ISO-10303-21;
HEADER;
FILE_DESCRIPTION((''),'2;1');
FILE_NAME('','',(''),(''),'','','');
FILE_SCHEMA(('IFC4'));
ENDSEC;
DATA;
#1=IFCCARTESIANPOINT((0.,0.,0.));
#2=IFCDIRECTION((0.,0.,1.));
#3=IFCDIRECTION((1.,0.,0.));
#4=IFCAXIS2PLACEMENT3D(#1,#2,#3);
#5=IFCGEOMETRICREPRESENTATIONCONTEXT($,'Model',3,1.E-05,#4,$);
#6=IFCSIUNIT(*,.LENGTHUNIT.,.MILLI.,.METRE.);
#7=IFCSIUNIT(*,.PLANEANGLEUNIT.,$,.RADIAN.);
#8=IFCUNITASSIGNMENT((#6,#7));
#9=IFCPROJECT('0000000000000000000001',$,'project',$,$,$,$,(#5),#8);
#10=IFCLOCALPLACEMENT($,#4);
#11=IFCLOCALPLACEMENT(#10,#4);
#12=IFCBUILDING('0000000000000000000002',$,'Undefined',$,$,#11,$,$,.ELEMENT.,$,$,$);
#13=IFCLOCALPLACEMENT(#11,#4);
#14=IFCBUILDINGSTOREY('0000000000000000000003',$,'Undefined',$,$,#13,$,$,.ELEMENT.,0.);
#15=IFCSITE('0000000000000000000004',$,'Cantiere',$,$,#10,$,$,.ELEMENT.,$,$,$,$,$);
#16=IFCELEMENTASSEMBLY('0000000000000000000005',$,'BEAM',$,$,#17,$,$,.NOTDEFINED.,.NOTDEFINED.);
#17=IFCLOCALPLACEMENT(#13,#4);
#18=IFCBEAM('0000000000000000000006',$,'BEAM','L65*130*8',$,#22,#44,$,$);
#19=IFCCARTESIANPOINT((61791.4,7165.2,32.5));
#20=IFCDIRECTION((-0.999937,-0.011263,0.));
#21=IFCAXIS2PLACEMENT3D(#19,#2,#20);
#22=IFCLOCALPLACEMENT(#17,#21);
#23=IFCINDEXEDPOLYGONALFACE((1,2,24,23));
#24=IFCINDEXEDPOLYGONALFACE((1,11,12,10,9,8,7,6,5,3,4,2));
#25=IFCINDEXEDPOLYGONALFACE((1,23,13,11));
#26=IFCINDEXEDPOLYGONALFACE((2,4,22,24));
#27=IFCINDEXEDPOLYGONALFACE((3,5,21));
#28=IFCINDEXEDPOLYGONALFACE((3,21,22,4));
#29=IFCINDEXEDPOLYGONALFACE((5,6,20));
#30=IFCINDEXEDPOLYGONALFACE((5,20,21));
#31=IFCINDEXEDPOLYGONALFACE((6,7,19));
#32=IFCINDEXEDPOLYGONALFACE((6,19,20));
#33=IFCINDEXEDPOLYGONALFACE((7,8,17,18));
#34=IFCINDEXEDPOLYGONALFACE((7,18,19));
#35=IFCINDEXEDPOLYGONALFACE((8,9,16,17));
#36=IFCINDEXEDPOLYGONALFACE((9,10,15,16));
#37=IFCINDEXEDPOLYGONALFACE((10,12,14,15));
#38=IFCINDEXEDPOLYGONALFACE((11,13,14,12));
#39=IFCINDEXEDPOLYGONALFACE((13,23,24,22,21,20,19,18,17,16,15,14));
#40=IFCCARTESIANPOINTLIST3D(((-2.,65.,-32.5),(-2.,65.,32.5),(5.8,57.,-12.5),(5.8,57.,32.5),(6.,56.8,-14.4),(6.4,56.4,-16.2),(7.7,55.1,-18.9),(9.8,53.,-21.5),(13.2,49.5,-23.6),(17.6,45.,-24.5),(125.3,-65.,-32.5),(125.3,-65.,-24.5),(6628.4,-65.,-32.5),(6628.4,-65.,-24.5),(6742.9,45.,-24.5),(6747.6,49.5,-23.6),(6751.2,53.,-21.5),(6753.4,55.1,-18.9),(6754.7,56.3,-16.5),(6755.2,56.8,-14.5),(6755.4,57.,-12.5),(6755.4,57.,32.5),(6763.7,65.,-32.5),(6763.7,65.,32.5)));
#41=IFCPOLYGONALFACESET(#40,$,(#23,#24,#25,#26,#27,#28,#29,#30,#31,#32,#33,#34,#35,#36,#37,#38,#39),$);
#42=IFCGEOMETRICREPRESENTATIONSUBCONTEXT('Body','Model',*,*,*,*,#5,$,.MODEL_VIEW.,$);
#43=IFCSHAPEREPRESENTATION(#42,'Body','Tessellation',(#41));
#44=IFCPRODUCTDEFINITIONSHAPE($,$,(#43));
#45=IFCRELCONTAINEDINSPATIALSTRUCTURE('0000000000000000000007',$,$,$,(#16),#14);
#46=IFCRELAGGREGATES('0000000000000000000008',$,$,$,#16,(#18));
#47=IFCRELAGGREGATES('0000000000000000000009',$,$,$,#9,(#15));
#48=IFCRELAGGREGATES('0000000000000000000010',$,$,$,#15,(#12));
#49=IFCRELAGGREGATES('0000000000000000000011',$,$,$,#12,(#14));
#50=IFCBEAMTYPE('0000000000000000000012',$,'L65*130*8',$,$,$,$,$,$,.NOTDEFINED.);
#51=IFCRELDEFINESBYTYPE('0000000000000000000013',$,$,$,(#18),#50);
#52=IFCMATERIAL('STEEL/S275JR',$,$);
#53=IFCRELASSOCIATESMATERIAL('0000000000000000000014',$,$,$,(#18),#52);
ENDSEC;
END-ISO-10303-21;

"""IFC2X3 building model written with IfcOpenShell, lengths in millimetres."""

from ifc_helpers import new_model, si_unit, frame, origin_with_axes, origin_2d_with_axis, place, context, subcontext, project, spatial, l_section, extrude, clip, halfspace, material, type_object, element, aggregate, save


model = new_model("IFC2X3")

# Units and contexts
model_context = context("Model", 3, precision=1e-05, world=origin_with_axes())
body_context = subcontext(model_context, "Body", "Model", "MODEL_VIEW")
ifc_project = project(units=[si_unit("LENGTHUNIT", "METRE", prefix="MILLI"), si_unit("PLANEANGLEUNIT", "RADIAN")], contexts=[model_context])

# Site, building, storey
site_placement = place(None, origin_with_axes())
site = spatial("IfcSite", under=ifc_project, at=site_placement, Name="Cantiere", CompositionType="ELEMENT")
building_placement = place(site_placement, origin_with_axes())
building = spatial("IfcBuilding", under=site, at=building_placement, Name="Undefined", CompositionType="ELEMENT")
storey_placement = place(building_placement, origin_with_axes())
storey = spatial("IfcBuildingStorey", under=building, at=storey_placement, Name="Undefined", CompositionType="ELEMENT", Elevation=0.0)

# Element assembly, beam
ifc_material_1 = material(Name="STEEL/S275JR")
beam_type_1 = type_object("IfcBeamType", Name="L65*130*8", PredefinedType="NOTDEFINED")
assembly_1_placement = place(storey_placement, origin_with_axes())
assembly_1 = element("IfcElementAssembly", 1, at=assembly_1_placement, inside=storey, Name="BEAM", AssemblyPlace="NOTDEFINED", PredefinedType="NOTDEFINED")
beam_1_placement = place(assembly_1_placement, frame((61791.4, 7165.2, 32.5), z_axis=(0.0, 0.0, 1.0), x_axis=(-0.999937, -0.011263, 0.0)))
beam_1 = element("IfcBeam", 2, at=beam_1_placement, type_object=beam_type_1, material=ifc_material_1, Name="BEAM", Description="L65*130*8", context=body_context, shape_type="Clipping", body=[
    clip(clip(extrude(l_section(Depth=65.0, Width=130.0, Thickness=8.0, FilletRadius=12.0, at=origin_2d_with_axis()), frame((6830.1, 0.0, 0.0), z_axis=(-1.0, 0.0, 0.0), x_axis=(0.0, -1.0, 0.0)), (0.0, 0.0, 1.0), 6902.6), halfspace(frame((6628.4, -65.0, -32.5), z_axis=(0.692766, -0.721163, 0.0), x_axis=(0.0, 0.0, 1.0)), False)), halfspace(frame((125.3, -65.0, -32.5), z_axis=(0.714491, 0.699645, 0.0), x_axis=(0.0, 0.0, 1.0)), True)),
])
aggregate(assembly_1, [beam_1])

save(model, "model.ifc")
